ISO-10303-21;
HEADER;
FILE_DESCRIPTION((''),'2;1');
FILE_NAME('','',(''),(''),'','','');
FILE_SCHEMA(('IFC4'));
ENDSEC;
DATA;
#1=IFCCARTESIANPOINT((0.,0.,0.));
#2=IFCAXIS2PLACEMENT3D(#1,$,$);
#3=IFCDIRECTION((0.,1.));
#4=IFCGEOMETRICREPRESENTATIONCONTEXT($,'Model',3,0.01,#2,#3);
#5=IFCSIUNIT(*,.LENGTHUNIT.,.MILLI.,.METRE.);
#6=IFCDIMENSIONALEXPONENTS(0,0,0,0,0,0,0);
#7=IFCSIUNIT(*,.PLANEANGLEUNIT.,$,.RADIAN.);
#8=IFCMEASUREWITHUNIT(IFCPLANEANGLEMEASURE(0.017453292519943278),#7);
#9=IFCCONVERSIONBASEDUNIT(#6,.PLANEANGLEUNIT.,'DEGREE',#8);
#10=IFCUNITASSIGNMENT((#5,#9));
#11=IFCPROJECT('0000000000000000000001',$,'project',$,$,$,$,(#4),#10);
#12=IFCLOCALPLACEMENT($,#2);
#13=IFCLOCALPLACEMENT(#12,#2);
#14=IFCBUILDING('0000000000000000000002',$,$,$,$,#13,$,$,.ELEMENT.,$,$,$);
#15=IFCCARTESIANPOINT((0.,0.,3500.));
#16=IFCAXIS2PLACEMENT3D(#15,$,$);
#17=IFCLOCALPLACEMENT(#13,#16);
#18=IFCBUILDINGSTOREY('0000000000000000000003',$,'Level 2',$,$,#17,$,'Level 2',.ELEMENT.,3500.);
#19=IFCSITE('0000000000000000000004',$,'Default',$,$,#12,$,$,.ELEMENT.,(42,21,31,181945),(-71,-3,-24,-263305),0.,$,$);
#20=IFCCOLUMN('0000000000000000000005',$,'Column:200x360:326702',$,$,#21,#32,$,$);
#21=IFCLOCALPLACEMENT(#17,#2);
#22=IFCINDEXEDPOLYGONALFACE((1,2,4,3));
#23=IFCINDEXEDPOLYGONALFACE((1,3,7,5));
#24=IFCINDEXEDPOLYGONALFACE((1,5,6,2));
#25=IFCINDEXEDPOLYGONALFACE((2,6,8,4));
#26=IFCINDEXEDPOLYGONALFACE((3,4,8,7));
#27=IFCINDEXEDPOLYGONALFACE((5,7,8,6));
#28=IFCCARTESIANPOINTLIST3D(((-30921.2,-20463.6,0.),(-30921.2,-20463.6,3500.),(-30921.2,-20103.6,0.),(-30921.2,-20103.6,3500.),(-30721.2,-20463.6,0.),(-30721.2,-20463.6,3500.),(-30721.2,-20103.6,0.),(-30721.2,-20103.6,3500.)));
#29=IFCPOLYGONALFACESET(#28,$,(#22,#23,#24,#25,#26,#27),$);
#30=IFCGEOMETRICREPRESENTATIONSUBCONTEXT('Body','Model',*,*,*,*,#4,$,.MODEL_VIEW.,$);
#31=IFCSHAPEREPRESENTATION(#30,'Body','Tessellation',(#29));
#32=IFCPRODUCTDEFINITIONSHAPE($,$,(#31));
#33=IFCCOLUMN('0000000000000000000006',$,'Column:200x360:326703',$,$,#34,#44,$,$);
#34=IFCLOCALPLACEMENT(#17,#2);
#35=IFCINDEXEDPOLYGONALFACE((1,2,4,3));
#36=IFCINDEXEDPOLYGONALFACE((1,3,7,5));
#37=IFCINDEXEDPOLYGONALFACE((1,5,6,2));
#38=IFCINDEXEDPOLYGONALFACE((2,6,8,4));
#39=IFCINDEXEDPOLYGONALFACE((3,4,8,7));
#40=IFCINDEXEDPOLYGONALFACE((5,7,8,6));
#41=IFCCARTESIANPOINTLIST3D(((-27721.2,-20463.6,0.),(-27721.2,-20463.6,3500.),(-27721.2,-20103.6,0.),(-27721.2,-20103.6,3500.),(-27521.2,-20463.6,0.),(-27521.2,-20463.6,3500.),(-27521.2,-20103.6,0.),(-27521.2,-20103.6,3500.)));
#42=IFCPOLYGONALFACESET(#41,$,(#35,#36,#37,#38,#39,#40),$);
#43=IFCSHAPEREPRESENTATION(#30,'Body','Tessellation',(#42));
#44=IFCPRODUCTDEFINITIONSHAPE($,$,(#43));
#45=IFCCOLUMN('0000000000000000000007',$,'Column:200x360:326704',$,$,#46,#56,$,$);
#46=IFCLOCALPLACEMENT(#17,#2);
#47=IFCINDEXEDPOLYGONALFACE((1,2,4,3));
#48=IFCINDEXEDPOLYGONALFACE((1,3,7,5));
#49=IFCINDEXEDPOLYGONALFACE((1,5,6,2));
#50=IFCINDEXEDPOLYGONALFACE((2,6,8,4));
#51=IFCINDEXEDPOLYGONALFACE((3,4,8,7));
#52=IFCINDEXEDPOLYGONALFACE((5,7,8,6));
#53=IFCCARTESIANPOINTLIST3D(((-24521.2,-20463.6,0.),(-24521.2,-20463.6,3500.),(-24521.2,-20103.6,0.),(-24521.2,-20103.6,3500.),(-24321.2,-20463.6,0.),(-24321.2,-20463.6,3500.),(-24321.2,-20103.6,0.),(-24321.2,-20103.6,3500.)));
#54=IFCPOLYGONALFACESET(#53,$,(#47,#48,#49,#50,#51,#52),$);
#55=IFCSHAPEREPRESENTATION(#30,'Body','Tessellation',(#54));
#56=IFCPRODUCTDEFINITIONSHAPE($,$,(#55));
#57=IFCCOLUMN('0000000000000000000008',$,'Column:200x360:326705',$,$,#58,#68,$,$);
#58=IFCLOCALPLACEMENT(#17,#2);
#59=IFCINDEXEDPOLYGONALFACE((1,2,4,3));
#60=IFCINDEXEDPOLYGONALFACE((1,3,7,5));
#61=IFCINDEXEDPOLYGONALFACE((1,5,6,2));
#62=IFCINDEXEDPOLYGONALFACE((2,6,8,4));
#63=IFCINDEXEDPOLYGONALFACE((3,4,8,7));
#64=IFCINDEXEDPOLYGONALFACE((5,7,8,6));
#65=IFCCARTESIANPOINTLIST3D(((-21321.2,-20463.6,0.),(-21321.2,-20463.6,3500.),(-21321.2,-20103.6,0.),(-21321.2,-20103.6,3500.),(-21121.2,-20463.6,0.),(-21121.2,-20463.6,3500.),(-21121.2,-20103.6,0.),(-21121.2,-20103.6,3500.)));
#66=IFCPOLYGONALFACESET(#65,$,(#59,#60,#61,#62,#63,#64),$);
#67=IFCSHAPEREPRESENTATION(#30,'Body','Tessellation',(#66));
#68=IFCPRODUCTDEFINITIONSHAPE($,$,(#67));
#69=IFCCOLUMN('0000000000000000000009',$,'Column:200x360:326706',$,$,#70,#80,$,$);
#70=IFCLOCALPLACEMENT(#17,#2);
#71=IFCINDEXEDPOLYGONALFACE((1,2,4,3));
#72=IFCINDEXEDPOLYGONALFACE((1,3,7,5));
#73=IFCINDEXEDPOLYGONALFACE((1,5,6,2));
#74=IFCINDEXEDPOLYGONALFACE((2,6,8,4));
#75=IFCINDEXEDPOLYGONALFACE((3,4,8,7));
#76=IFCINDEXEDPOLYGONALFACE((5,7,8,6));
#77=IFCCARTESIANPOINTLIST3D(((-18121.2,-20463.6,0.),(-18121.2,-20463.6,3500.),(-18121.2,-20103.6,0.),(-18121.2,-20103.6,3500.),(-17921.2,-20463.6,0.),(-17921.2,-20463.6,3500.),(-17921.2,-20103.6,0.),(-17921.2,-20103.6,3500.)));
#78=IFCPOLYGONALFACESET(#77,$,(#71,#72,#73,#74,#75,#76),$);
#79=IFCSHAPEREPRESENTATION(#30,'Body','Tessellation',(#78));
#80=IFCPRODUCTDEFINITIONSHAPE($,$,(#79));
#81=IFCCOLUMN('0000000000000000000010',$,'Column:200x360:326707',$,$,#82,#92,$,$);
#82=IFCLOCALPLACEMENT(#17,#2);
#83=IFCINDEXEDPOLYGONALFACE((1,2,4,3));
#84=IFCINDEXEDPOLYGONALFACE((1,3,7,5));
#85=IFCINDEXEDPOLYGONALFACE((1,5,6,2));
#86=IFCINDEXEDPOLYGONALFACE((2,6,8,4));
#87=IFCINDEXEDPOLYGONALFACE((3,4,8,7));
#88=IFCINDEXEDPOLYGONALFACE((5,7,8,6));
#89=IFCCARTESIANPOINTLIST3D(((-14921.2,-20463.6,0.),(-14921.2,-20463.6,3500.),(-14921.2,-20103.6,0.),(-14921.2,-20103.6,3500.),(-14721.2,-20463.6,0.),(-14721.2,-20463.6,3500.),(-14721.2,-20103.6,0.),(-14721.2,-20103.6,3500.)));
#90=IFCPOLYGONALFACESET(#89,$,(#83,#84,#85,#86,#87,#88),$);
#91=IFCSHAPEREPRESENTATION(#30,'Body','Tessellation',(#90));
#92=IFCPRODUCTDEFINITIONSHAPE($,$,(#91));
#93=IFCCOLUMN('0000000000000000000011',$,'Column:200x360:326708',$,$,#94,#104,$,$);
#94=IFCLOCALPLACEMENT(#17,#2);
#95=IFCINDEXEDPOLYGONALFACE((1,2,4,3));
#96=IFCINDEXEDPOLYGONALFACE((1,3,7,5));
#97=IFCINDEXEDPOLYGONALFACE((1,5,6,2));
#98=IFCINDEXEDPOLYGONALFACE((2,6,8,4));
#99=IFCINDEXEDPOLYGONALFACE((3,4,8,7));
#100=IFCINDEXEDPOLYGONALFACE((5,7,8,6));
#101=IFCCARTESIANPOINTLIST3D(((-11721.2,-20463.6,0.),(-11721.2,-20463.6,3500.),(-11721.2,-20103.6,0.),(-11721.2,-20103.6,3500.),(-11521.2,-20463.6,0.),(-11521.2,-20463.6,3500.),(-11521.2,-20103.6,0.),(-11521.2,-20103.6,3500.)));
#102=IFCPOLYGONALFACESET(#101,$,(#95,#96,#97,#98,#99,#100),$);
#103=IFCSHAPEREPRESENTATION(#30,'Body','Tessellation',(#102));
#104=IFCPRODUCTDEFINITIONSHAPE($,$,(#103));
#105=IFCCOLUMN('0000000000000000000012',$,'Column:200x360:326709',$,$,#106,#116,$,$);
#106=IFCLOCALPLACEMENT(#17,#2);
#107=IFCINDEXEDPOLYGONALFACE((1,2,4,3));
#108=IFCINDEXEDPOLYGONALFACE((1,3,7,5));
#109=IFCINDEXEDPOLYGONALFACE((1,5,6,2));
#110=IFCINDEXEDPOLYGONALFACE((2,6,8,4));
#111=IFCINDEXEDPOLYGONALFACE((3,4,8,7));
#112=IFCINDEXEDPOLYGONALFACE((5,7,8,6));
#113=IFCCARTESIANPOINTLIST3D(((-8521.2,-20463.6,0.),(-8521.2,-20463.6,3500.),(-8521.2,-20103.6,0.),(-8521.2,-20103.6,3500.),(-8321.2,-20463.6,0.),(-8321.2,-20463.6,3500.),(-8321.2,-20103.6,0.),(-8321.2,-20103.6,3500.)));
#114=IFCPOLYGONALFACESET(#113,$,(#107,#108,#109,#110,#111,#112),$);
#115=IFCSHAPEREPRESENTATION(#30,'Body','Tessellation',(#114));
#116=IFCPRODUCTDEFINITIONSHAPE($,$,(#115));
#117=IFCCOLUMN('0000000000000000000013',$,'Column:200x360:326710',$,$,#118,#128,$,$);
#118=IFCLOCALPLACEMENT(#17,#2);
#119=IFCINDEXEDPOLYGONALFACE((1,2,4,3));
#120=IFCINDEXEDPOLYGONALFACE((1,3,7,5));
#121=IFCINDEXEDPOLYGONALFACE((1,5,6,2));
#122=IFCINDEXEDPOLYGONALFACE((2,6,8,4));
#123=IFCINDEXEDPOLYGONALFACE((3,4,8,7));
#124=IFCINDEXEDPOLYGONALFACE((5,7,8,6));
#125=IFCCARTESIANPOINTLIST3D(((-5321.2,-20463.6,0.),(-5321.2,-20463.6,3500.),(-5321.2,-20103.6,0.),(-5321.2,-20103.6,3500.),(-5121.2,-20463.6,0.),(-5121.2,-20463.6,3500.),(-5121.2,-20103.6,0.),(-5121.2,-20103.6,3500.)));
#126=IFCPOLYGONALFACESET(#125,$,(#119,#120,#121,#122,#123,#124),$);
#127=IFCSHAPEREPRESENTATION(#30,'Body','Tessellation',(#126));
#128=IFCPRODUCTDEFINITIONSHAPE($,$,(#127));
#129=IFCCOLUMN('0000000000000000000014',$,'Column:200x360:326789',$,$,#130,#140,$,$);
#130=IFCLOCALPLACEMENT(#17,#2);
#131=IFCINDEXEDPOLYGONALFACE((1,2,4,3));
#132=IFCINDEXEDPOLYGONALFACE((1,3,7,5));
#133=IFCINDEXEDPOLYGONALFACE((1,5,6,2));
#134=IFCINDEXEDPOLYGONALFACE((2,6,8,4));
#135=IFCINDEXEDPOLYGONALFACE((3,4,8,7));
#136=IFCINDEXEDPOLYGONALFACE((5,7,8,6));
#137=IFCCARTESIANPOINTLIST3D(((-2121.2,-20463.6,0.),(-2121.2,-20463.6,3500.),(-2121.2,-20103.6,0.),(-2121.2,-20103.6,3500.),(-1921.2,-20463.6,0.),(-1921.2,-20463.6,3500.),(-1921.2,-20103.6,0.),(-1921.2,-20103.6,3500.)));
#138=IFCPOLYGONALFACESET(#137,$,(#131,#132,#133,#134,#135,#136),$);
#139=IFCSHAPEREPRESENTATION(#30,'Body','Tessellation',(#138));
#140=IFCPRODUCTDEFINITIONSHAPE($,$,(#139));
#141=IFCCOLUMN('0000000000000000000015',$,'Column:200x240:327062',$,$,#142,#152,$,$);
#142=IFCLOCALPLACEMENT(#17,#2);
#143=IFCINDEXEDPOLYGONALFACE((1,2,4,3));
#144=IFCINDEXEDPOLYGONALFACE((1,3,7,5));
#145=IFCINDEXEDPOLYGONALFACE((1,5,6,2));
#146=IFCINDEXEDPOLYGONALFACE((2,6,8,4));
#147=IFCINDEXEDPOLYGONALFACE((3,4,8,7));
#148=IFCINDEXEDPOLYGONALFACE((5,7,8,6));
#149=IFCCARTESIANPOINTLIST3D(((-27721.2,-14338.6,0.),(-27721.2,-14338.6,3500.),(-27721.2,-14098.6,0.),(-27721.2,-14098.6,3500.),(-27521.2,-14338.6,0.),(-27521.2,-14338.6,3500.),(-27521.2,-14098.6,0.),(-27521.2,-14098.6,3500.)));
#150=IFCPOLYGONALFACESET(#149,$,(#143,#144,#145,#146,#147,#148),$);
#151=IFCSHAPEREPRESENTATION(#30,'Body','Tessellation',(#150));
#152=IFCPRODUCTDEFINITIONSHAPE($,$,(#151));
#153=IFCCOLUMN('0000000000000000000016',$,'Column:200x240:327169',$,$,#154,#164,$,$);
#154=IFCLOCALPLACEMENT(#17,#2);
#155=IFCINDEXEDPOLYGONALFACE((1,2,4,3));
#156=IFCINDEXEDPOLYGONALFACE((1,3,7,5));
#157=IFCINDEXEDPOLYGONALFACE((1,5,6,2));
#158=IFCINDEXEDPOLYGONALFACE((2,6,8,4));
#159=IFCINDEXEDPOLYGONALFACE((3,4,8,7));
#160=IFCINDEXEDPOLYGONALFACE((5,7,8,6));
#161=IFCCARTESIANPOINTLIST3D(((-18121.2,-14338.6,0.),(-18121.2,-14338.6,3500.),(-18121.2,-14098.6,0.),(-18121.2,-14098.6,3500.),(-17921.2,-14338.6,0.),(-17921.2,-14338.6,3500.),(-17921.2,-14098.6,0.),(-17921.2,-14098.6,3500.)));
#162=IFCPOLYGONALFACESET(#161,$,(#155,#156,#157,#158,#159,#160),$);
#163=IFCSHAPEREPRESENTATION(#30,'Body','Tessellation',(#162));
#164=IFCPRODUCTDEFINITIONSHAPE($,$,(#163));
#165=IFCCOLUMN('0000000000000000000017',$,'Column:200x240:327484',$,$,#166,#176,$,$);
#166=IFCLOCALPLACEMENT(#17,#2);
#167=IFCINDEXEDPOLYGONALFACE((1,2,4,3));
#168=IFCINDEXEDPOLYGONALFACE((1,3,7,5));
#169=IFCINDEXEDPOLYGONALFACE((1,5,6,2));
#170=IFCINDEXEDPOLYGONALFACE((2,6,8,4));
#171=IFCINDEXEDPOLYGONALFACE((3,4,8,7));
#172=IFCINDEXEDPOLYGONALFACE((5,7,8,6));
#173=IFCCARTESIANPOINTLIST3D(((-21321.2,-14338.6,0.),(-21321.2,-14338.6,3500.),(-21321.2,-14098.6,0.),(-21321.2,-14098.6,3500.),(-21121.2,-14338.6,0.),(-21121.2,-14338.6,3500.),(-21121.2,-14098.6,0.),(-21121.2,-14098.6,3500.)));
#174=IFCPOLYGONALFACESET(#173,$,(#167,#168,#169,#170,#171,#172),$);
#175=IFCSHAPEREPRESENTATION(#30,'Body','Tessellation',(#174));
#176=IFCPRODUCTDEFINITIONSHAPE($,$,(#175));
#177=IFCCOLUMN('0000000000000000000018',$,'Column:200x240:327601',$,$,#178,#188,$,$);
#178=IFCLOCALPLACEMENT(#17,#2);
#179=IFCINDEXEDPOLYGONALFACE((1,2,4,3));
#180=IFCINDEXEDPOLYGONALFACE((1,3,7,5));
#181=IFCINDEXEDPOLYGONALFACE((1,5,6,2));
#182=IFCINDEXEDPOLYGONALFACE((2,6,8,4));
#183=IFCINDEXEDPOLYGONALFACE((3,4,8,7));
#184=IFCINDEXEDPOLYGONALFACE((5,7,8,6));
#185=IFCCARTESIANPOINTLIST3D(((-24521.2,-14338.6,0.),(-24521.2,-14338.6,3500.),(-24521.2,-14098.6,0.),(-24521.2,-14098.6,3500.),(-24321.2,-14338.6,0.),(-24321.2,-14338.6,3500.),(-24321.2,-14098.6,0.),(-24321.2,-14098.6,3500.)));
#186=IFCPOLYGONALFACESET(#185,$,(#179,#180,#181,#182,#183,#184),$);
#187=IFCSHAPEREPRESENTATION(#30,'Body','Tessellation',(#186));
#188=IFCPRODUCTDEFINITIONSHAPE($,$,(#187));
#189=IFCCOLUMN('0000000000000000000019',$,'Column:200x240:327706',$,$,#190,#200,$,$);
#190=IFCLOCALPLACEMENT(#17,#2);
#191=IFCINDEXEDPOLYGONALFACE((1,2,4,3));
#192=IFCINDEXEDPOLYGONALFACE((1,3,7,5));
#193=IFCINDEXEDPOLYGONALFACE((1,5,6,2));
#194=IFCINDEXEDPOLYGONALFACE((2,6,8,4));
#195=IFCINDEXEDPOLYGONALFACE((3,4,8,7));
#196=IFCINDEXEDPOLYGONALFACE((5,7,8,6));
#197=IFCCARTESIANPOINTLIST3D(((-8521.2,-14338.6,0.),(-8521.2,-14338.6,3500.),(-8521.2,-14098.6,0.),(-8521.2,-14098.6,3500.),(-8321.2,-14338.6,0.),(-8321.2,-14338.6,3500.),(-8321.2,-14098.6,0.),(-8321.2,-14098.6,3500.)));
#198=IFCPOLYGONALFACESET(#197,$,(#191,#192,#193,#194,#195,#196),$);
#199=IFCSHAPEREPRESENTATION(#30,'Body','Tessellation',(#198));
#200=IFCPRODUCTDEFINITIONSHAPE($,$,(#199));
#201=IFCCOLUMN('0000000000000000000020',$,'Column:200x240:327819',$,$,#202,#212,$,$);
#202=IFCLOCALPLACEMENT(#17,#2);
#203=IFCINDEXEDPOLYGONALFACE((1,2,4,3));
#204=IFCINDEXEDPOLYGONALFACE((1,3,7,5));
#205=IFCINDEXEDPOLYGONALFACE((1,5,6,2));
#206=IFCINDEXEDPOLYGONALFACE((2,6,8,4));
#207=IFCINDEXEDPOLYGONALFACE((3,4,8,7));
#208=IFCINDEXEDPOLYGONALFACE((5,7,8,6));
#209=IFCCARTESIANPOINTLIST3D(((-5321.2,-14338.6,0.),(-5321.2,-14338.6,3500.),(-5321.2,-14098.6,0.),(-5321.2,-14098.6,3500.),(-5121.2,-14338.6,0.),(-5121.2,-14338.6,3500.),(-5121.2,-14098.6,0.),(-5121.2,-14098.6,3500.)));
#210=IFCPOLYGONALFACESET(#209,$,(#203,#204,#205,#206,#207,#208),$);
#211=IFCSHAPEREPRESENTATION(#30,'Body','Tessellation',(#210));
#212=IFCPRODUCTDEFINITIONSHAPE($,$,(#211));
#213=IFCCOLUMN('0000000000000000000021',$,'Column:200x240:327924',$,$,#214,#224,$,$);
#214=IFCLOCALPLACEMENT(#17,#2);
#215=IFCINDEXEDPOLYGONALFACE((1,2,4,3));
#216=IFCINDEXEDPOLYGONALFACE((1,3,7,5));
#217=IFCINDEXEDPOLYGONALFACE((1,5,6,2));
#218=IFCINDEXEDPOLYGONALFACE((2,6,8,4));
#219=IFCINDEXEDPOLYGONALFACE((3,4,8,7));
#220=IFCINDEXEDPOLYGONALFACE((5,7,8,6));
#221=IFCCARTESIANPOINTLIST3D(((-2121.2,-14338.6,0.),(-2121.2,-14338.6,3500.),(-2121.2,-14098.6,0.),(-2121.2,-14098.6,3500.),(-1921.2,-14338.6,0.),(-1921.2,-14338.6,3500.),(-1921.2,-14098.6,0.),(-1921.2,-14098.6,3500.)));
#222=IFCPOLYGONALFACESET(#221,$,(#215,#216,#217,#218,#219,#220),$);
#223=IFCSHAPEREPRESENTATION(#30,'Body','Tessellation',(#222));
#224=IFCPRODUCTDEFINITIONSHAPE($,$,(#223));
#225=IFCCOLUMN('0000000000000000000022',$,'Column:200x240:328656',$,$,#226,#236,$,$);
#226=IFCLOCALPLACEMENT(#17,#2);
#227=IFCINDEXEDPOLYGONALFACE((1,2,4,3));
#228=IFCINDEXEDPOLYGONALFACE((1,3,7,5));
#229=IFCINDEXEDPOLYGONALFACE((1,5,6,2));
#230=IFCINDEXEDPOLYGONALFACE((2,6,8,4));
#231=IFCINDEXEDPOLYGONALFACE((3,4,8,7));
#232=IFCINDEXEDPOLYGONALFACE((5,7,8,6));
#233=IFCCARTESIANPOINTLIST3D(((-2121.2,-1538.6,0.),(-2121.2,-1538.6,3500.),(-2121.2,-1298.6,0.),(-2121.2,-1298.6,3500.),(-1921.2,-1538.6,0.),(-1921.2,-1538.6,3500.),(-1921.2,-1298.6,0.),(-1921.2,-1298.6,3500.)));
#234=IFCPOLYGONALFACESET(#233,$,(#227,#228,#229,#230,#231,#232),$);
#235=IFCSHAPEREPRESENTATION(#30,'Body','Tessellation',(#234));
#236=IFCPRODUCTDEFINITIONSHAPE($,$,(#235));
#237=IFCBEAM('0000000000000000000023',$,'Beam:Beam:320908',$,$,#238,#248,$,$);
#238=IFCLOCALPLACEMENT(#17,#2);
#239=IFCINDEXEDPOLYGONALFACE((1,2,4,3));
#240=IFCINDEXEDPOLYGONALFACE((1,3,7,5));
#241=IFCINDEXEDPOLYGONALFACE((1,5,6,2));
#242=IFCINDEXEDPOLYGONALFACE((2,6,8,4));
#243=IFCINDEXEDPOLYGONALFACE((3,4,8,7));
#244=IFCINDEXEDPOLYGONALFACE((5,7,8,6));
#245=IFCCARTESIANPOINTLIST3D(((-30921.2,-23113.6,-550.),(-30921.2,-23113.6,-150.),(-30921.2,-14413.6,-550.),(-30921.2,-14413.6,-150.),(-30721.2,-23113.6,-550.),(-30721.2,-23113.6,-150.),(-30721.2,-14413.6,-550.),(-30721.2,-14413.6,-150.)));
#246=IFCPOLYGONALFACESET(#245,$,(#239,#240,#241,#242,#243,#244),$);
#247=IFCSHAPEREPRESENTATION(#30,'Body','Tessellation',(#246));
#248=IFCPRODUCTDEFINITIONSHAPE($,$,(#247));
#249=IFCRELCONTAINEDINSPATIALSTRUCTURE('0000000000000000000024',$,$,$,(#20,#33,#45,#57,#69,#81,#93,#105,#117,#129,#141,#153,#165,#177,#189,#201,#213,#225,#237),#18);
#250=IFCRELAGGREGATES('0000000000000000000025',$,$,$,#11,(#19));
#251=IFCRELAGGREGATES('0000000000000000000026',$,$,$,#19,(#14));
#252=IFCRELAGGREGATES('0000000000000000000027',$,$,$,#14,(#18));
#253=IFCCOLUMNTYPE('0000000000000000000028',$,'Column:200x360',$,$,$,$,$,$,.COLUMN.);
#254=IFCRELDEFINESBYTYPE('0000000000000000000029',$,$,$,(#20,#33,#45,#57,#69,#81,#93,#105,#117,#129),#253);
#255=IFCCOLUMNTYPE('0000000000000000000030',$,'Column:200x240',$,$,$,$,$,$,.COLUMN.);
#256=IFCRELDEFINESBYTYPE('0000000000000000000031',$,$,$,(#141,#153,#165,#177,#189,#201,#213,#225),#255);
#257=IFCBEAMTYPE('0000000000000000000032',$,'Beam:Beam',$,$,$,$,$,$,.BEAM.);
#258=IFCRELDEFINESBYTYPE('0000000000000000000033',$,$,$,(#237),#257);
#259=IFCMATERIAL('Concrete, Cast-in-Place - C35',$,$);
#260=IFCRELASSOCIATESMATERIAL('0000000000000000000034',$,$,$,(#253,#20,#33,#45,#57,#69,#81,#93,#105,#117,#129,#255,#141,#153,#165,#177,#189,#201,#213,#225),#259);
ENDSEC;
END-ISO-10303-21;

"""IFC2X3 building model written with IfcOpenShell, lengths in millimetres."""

from ifc_helpers import new_model, entity, si_unit, converted_unit, direction, frame, frame_2d, origin, place, context, subcontext, project, spatial, rectangle, extrude, source, transform, mapped, material, type_object, type_shapes, element, save


model = new_model("IFC2X3")

# Units and contexts
model_context = context("Model", 3, precision=0.01, world=origin(), true_north=direction((0.0, 1.0)))
body_context = subcontext(model_context, "Body", "Model", "MODEL_VIEW")
ifc_project = project(units=[si_unit("LENGTHUNIT", "METRE", prefix="MILLI"), converted_unit("PLANEANGLEUNIT", "DEGREE", entity("IfcPlaneAngleMeasure", 0.017453292519943278), si_unit("PLANEANGLEUNIT", "RADIAN"), dimensions=[0, 0, 0, 0, 0, 0, 0])], contexts=[model_context])

# Site, building, storey
site_placement = place(None, origin())
site = spatial("IfcSite", under=ifc_project, at=site_placement, Name="Default", CompositionType="ELEMENT", RefLatitude=(42, 21, 31, 181945), RefLongitude=(-71, -3, -24, -263305), RefElevation=0.0)
building_placement = place(site_placement, origin())
building = spatial("IfcBuilding", under=site, at=building_placement, CompositionType="ELEMENT")
storey_placement = place(building_placement, frame((0.0, 0.0, 3500.0)))
storey = spatial("IfcBuildingStorey", under=building, at=storey_placement, Name="Level 2", LongName="Level 2", CompositionType="ELEMENT", Elevation=3500.0)

# Columns
ifc_material_1 = material(Name="Concrete, Cast-in-Place - C35")
column_type_1 = type_object("IfcColumnType", Name="Column:200x360", PredefinedType="COLUMN", material=ifc_material_1)
shared_shape_1 = source(origin(), body_context, "Body", "SweptSolid", [
    extrude(rectangle(XDim=200.0, YDim=360.0, at=frame_2d((0.0, 0.0), x_axis=(1.0, 0.0))), frame((0.0, 80.0, 3500.0), z_axis=(0.0, 0.0, 1.0), x_axis=(-1.0, 0.0, 0.0)), (0.0, 0.0, 1.0), 3500.0),
])
type_shapes(column_type_1, [shared_shape_1])
for number, where, name in (
    (1, (-30821.2, -20363.6, -3500.0), "Column:200x360:326702"),
    (2, (-27621.2, -20363.6, -3500.0), "Column:200x360:326703"),
    (3, (-24421.2, -20363.6, -3500.0), "Column:200x360:326704"),
    (4, (-21221.2, -20363.6, -3500.0), "Column:200x360:326705"),
    (5, (-18021.2, -20363.6, -3500.0), "Column:200x360:326706"),
    (6, (-14821.2, -20363.6, -3500.0), "Column:200x360:326707"),
    (7, (-11621.2, -20363.6, -3500.0), "Column:200x360:326708"),
    (8, (-8421.2, -20363.6, -3500.0), "Column:200x360:326709"),
    (9, (-5221.2, -20363.6, -3500.0), "Column:200x360:326710"),
    (10, (-2021.2, -20363.6, -3500.0), "Column:200x360:326789"),
):
    element("IfcColumn", number, at=place(storey_placement, frame(where)), inside=storey, type_object=column_type_1, material=ifc_material_1, Name=name, context=body_context, shape_type="MappedRepresentation", body=[
        mapped(shared_shape_1, transform((0.0, 0.0, 0.0), scale=1.0)),
    ])
column_type_2 = type_object("IfcColumnType", Name="Column:200x240", PredefinedType="COLUMN", material=ifc_material_1)
shared_shape_2 = source(origin(), body_context, "Body", "SweptSolid", [
    extrude(rectangle(XDim=200.0, YDim=240.0, at=frame_2d((0.0, 0.0), x_axis=(1.0, 0.0))), frame((0.0, 20.0, 3500.0), z_axis=(0.0, 0.0, 1.0), x_axis=(-1.0, 0.0, 0.0)), (0.0, 0.0, 1.0), 3500.0),
])
type_shapes(column_type_2, [shared_shape_2])
for number, where, name in (
    (11, (-27621.2, -14238.6, -3500.0), "Column:200x240:327062"),
    (12, (-18021.2, -14238.6, -3500.0), "Column:200x240:327169"),
    (13, (-21221.2, -14238.6, -3500.0), "Column:200x240:327484"),
    (14, (-24421.2, -14238.6, -3500.0), "Column:200x240:327601"),
    (15, (-8421.2, -14238.6, -3500.0), "Column:200x240:327706"),
    (16, (-5221.2, -14238.6, -3500.0), "Column:200x240:327819"),
    (17, (-2021.2, -14238.6, -3500.0), "Column:200x240:327924"),
    (18, (-2021.2, -1438.6, -3500.0), "Column:200x240:328656"),
):
    element("IfcColumn", number, at=place(storey_placement, frame(where)), inside=storey, type_object=column_type_2, material=ifc_material_1, Name=name, context=body_context, shape_type="MappedRepresentation", body=[
        mapped(shared_shape_2, transform((0.0, 0.0, 0.0), scale=1.0)),
    ])

# Beam
beam_type = type_object("IfcBeamType", Name="Beam:Beam", PredefinedType="BEAM")
beam_1_placement = place(storey_placement, frame((-30846.2, -14413.6, -150.0), z_axis=(0.0, 0.0, 1.0), x_axis=(0.0, -1.0, 0.0)))
element("IfcBeam", 19, at=beam_1_placement, inside=storey, type_object=beam_type, Name="Beam:Beam:320908", context=body_context, shape_type="SweptSolid", body=[
    extrude(rectangle(XDim=400.0, YDim=200.0, at=frame_2d((0.0, 0.0), x_axis=(1.0, 0.0))), frame((0.0, 25.0, -200.0), z_axis=(1.0, 0.0, 0.0), x_axis=(0.0, 0.0, -1.0)), (0.0, 0.0, 1.0), 8700.0),
])

save(model, "model.ifc")
